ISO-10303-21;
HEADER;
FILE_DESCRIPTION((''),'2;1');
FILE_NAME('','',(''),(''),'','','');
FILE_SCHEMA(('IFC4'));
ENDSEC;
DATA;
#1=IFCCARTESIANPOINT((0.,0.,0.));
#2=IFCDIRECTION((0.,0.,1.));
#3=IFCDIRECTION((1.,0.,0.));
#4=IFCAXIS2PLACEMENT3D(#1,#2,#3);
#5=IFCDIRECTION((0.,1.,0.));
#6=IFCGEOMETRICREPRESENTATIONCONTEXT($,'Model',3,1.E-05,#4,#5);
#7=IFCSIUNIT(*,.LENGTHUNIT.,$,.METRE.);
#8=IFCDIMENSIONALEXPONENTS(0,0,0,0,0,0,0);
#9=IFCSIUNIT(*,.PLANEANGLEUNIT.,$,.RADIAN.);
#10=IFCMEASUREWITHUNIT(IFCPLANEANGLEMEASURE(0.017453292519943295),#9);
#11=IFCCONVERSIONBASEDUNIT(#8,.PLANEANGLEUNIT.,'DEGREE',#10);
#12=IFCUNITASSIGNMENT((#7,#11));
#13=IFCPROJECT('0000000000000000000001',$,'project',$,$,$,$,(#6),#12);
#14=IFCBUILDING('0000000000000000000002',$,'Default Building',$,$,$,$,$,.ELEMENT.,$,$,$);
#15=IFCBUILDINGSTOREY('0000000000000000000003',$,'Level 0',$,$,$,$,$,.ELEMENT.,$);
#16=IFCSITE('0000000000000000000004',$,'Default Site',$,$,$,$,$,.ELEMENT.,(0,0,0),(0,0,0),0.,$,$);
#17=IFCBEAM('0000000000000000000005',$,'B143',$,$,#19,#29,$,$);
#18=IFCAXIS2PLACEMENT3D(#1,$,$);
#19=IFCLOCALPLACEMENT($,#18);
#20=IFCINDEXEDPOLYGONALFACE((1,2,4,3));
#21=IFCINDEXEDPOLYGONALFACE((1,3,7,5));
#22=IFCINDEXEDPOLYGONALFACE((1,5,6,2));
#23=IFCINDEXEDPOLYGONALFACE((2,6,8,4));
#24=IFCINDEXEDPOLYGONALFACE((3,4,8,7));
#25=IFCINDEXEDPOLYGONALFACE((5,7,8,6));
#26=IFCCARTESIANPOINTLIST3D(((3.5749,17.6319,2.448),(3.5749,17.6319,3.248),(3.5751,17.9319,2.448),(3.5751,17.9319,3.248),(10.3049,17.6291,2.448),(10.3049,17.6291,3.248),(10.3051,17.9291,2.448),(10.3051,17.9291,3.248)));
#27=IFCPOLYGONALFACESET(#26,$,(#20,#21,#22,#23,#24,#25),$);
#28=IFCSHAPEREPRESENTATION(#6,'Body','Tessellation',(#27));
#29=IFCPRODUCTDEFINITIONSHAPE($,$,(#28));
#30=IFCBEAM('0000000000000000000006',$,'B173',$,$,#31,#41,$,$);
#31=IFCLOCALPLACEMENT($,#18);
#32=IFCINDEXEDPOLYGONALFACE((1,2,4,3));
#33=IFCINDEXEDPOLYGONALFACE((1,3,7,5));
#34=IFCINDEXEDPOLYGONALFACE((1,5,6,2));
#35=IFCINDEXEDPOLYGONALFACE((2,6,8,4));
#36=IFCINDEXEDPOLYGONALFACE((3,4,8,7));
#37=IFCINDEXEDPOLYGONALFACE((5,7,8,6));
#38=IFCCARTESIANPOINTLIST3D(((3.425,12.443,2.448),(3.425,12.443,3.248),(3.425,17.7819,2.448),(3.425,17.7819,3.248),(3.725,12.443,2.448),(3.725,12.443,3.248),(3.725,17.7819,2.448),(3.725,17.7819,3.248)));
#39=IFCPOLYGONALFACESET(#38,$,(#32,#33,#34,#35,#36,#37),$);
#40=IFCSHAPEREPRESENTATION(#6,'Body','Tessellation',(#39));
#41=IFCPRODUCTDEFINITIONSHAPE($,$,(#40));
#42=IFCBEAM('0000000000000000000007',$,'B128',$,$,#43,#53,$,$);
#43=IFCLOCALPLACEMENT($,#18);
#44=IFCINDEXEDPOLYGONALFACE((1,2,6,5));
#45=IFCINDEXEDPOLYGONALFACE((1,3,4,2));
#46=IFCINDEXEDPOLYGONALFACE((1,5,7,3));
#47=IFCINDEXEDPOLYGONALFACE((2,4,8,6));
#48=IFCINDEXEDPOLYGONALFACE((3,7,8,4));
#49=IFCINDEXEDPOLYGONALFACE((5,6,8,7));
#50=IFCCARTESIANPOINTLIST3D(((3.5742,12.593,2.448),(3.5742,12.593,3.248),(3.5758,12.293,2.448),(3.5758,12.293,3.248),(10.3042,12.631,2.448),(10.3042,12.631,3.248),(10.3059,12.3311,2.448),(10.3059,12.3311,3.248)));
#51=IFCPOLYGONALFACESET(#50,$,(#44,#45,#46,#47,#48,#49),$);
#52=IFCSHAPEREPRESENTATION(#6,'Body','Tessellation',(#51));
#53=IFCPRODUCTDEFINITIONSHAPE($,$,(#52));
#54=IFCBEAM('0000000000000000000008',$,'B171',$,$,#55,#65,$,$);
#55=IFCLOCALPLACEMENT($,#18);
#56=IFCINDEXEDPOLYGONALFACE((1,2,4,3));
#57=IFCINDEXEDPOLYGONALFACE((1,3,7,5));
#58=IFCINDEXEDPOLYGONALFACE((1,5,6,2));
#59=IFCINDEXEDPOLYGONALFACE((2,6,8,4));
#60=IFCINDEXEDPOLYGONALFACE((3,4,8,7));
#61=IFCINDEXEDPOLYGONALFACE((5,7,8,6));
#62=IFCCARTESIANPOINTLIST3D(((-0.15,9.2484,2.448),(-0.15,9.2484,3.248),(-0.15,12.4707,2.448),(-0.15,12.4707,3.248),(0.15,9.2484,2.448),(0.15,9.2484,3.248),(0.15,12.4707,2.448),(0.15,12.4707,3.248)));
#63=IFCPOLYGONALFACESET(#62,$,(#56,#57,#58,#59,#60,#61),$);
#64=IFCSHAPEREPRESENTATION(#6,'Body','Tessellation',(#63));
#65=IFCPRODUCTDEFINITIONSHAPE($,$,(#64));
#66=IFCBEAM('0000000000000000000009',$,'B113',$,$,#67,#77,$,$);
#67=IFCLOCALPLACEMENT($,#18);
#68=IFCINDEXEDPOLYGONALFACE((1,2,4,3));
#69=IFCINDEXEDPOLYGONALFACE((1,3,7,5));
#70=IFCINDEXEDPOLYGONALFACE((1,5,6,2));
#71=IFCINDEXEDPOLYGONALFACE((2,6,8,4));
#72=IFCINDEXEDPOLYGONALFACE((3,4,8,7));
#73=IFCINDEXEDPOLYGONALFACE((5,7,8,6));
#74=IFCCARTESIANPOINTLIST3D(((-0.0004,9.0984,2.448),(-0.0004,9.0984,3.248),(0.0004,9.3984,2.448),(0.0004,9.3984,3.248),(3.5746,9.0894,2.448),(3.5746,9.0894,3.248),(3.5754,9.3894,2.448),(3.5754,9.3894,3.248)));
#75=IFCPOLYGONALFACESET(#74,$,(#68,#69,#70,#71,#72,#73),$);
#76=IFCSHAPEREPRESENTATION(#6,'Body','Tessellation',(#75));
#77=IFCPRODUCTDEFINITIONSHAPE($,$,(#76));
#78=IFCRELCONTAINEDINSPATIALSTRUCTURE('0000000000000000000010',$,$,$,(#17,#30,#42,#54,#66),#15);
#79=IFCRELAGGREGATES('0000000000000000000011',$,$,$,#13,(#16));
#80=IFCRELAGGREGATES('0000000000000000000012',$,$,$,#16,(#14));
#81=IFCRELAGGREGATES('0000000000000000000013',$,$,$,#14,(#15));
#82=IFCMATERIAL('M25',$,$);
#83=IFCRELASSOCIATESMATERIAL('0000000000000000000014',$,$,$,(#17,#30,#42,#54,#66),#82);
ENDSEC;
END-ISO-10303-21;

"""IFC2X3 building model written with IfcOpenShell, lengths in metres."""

from ifc_helpers import new_model, entity, si_unit, converted_unit, direction, frame, frame_2d, origin_with_axes, place, context, project, spatial, rectangle, extrude, material, element, save


model = new_model("IFC2X3")

# Units and contexts
model_context = context("Model", 3, precision=1e-05, world=origin_with_axes(), true_north=direction((0.0, 1.0, 0.0)))
ifc_project = project(units=[si_unit("LENGTHUNIT", "METRE"), converted_unit("PLANEANGLEUNIT", "DEGREE", entity("IfcPlaneAngleMeasure", 0.017453292519943295), si_unit("PLANEANGLEUNIT", "RADIAN"), dimensions=[0, 0, 0, 0, 0, 0, 0])], contexts=[model_context])

# Site, building, storey
site = spatial("IfcSite", under=ifc_project, Name="Default Site", CompositionType="ELEMENT", RefLatitude=(0, 0, 0), RefLongitude=(0, 0, 0), RefElevation=0.0)
building = spatial("IfcBuilding", under=site, Name="Default Building", CompositionType="ELEMENT")
storey = spatial("IfcBuildingStorey", under=building, Name="Level 0", CompositionType="ELEMENT")

# Beams
ifc_material = material(Name="M25")
placement = place(None, origin_with_axes())
element("IfcBeam", 1, at=placement, inside=storey, material=ifc_material, Name="B143", context=model_context, shape_type="SweptSolid", body=[
    extrude(rectangle(XDim=0.3, YDim=0.8, at=frame_2d((0.0, 0.0), x_axis=(0.0, 1.0, 0.0))), frame((10.305, 17.7791, 2.848), z_axis=(-1.0, 0.000419, 0.0), x_axis=(0.0, 0.0, -1.0)), (0.0, 0.0, 1.0), 6.73),
])
element("IfcBeam", 2, at=placement, inside=storey, material=ifc_material, Name="B173", context=model_context, shape_type="SweptSolid", body=[
    extrude(rectangle(XDim=0.3, YDim=0.8, at=frame_2d((0.0, 0.0), x_axis=(0.0, 1.0, 0.0))), frame((3.575, 12.443, 2.848), z_axis=(0.0, 1.0, 0.0), x_axis=(0.0, 0.0, -1.0)), (0.0, 0.0, 1.0), 5.3389),
])
element("IfcBeam", 3, at=placement, inside=storey, material=ifc_material, Name="B128", context=model_context, shape_type="SweptSolid", body=[
    extrude(rectangle(XDim=0.3, YDim=0.8, at=frame_2d((0.0, 0.0), x_axis=(0.0, 1.0, 0.0))), frame((3.575, 12.443, 2.848), z_axis=(0.999984, 0.005654, 0.0), x_axis=(0.0, 0.0, -1.0)), (0.0, 0.0, 1.0), 6.7301),
])
element("IfcBeam", 4, at=placement, inside=storey, material=ifc_material, Name="B171", context=model_context, shape_type="SweptSolid", body=[
    extrude(rectangle(XDim=0.3, YDim=0.8, at=frame_2d((0.0, 0.0), x_axis=(0.0, 1.0, 0.0))), frame((0.0, 9.2484, 2.848), z_axis=(0.0, 1.0, 0.0), x_axis=(0.0, 0.0, -1.0)), (0.0, 0.0, 1.0), 3.2223),
])
element("IfcBeam", 5, at=placement, inside=storey, material=ifc_material, Name="B113", context=model_context, shape_type="SweptSolid", body=[
    extrude(rectangle(XDim=0.3, YDim=0.8, at=frame_2d((0.0, 0.0), x_axis=(0.0, 1.0, 0.0))), frame((0.0, 9.2484, 2.848), z_axis=(0.999997, -0.002499, 0.0), x_axis=(0.0, 0.0, -1.0)), (0.0, 0.0, 1.0), 3.575),
])

save(model, "model.ifc")
